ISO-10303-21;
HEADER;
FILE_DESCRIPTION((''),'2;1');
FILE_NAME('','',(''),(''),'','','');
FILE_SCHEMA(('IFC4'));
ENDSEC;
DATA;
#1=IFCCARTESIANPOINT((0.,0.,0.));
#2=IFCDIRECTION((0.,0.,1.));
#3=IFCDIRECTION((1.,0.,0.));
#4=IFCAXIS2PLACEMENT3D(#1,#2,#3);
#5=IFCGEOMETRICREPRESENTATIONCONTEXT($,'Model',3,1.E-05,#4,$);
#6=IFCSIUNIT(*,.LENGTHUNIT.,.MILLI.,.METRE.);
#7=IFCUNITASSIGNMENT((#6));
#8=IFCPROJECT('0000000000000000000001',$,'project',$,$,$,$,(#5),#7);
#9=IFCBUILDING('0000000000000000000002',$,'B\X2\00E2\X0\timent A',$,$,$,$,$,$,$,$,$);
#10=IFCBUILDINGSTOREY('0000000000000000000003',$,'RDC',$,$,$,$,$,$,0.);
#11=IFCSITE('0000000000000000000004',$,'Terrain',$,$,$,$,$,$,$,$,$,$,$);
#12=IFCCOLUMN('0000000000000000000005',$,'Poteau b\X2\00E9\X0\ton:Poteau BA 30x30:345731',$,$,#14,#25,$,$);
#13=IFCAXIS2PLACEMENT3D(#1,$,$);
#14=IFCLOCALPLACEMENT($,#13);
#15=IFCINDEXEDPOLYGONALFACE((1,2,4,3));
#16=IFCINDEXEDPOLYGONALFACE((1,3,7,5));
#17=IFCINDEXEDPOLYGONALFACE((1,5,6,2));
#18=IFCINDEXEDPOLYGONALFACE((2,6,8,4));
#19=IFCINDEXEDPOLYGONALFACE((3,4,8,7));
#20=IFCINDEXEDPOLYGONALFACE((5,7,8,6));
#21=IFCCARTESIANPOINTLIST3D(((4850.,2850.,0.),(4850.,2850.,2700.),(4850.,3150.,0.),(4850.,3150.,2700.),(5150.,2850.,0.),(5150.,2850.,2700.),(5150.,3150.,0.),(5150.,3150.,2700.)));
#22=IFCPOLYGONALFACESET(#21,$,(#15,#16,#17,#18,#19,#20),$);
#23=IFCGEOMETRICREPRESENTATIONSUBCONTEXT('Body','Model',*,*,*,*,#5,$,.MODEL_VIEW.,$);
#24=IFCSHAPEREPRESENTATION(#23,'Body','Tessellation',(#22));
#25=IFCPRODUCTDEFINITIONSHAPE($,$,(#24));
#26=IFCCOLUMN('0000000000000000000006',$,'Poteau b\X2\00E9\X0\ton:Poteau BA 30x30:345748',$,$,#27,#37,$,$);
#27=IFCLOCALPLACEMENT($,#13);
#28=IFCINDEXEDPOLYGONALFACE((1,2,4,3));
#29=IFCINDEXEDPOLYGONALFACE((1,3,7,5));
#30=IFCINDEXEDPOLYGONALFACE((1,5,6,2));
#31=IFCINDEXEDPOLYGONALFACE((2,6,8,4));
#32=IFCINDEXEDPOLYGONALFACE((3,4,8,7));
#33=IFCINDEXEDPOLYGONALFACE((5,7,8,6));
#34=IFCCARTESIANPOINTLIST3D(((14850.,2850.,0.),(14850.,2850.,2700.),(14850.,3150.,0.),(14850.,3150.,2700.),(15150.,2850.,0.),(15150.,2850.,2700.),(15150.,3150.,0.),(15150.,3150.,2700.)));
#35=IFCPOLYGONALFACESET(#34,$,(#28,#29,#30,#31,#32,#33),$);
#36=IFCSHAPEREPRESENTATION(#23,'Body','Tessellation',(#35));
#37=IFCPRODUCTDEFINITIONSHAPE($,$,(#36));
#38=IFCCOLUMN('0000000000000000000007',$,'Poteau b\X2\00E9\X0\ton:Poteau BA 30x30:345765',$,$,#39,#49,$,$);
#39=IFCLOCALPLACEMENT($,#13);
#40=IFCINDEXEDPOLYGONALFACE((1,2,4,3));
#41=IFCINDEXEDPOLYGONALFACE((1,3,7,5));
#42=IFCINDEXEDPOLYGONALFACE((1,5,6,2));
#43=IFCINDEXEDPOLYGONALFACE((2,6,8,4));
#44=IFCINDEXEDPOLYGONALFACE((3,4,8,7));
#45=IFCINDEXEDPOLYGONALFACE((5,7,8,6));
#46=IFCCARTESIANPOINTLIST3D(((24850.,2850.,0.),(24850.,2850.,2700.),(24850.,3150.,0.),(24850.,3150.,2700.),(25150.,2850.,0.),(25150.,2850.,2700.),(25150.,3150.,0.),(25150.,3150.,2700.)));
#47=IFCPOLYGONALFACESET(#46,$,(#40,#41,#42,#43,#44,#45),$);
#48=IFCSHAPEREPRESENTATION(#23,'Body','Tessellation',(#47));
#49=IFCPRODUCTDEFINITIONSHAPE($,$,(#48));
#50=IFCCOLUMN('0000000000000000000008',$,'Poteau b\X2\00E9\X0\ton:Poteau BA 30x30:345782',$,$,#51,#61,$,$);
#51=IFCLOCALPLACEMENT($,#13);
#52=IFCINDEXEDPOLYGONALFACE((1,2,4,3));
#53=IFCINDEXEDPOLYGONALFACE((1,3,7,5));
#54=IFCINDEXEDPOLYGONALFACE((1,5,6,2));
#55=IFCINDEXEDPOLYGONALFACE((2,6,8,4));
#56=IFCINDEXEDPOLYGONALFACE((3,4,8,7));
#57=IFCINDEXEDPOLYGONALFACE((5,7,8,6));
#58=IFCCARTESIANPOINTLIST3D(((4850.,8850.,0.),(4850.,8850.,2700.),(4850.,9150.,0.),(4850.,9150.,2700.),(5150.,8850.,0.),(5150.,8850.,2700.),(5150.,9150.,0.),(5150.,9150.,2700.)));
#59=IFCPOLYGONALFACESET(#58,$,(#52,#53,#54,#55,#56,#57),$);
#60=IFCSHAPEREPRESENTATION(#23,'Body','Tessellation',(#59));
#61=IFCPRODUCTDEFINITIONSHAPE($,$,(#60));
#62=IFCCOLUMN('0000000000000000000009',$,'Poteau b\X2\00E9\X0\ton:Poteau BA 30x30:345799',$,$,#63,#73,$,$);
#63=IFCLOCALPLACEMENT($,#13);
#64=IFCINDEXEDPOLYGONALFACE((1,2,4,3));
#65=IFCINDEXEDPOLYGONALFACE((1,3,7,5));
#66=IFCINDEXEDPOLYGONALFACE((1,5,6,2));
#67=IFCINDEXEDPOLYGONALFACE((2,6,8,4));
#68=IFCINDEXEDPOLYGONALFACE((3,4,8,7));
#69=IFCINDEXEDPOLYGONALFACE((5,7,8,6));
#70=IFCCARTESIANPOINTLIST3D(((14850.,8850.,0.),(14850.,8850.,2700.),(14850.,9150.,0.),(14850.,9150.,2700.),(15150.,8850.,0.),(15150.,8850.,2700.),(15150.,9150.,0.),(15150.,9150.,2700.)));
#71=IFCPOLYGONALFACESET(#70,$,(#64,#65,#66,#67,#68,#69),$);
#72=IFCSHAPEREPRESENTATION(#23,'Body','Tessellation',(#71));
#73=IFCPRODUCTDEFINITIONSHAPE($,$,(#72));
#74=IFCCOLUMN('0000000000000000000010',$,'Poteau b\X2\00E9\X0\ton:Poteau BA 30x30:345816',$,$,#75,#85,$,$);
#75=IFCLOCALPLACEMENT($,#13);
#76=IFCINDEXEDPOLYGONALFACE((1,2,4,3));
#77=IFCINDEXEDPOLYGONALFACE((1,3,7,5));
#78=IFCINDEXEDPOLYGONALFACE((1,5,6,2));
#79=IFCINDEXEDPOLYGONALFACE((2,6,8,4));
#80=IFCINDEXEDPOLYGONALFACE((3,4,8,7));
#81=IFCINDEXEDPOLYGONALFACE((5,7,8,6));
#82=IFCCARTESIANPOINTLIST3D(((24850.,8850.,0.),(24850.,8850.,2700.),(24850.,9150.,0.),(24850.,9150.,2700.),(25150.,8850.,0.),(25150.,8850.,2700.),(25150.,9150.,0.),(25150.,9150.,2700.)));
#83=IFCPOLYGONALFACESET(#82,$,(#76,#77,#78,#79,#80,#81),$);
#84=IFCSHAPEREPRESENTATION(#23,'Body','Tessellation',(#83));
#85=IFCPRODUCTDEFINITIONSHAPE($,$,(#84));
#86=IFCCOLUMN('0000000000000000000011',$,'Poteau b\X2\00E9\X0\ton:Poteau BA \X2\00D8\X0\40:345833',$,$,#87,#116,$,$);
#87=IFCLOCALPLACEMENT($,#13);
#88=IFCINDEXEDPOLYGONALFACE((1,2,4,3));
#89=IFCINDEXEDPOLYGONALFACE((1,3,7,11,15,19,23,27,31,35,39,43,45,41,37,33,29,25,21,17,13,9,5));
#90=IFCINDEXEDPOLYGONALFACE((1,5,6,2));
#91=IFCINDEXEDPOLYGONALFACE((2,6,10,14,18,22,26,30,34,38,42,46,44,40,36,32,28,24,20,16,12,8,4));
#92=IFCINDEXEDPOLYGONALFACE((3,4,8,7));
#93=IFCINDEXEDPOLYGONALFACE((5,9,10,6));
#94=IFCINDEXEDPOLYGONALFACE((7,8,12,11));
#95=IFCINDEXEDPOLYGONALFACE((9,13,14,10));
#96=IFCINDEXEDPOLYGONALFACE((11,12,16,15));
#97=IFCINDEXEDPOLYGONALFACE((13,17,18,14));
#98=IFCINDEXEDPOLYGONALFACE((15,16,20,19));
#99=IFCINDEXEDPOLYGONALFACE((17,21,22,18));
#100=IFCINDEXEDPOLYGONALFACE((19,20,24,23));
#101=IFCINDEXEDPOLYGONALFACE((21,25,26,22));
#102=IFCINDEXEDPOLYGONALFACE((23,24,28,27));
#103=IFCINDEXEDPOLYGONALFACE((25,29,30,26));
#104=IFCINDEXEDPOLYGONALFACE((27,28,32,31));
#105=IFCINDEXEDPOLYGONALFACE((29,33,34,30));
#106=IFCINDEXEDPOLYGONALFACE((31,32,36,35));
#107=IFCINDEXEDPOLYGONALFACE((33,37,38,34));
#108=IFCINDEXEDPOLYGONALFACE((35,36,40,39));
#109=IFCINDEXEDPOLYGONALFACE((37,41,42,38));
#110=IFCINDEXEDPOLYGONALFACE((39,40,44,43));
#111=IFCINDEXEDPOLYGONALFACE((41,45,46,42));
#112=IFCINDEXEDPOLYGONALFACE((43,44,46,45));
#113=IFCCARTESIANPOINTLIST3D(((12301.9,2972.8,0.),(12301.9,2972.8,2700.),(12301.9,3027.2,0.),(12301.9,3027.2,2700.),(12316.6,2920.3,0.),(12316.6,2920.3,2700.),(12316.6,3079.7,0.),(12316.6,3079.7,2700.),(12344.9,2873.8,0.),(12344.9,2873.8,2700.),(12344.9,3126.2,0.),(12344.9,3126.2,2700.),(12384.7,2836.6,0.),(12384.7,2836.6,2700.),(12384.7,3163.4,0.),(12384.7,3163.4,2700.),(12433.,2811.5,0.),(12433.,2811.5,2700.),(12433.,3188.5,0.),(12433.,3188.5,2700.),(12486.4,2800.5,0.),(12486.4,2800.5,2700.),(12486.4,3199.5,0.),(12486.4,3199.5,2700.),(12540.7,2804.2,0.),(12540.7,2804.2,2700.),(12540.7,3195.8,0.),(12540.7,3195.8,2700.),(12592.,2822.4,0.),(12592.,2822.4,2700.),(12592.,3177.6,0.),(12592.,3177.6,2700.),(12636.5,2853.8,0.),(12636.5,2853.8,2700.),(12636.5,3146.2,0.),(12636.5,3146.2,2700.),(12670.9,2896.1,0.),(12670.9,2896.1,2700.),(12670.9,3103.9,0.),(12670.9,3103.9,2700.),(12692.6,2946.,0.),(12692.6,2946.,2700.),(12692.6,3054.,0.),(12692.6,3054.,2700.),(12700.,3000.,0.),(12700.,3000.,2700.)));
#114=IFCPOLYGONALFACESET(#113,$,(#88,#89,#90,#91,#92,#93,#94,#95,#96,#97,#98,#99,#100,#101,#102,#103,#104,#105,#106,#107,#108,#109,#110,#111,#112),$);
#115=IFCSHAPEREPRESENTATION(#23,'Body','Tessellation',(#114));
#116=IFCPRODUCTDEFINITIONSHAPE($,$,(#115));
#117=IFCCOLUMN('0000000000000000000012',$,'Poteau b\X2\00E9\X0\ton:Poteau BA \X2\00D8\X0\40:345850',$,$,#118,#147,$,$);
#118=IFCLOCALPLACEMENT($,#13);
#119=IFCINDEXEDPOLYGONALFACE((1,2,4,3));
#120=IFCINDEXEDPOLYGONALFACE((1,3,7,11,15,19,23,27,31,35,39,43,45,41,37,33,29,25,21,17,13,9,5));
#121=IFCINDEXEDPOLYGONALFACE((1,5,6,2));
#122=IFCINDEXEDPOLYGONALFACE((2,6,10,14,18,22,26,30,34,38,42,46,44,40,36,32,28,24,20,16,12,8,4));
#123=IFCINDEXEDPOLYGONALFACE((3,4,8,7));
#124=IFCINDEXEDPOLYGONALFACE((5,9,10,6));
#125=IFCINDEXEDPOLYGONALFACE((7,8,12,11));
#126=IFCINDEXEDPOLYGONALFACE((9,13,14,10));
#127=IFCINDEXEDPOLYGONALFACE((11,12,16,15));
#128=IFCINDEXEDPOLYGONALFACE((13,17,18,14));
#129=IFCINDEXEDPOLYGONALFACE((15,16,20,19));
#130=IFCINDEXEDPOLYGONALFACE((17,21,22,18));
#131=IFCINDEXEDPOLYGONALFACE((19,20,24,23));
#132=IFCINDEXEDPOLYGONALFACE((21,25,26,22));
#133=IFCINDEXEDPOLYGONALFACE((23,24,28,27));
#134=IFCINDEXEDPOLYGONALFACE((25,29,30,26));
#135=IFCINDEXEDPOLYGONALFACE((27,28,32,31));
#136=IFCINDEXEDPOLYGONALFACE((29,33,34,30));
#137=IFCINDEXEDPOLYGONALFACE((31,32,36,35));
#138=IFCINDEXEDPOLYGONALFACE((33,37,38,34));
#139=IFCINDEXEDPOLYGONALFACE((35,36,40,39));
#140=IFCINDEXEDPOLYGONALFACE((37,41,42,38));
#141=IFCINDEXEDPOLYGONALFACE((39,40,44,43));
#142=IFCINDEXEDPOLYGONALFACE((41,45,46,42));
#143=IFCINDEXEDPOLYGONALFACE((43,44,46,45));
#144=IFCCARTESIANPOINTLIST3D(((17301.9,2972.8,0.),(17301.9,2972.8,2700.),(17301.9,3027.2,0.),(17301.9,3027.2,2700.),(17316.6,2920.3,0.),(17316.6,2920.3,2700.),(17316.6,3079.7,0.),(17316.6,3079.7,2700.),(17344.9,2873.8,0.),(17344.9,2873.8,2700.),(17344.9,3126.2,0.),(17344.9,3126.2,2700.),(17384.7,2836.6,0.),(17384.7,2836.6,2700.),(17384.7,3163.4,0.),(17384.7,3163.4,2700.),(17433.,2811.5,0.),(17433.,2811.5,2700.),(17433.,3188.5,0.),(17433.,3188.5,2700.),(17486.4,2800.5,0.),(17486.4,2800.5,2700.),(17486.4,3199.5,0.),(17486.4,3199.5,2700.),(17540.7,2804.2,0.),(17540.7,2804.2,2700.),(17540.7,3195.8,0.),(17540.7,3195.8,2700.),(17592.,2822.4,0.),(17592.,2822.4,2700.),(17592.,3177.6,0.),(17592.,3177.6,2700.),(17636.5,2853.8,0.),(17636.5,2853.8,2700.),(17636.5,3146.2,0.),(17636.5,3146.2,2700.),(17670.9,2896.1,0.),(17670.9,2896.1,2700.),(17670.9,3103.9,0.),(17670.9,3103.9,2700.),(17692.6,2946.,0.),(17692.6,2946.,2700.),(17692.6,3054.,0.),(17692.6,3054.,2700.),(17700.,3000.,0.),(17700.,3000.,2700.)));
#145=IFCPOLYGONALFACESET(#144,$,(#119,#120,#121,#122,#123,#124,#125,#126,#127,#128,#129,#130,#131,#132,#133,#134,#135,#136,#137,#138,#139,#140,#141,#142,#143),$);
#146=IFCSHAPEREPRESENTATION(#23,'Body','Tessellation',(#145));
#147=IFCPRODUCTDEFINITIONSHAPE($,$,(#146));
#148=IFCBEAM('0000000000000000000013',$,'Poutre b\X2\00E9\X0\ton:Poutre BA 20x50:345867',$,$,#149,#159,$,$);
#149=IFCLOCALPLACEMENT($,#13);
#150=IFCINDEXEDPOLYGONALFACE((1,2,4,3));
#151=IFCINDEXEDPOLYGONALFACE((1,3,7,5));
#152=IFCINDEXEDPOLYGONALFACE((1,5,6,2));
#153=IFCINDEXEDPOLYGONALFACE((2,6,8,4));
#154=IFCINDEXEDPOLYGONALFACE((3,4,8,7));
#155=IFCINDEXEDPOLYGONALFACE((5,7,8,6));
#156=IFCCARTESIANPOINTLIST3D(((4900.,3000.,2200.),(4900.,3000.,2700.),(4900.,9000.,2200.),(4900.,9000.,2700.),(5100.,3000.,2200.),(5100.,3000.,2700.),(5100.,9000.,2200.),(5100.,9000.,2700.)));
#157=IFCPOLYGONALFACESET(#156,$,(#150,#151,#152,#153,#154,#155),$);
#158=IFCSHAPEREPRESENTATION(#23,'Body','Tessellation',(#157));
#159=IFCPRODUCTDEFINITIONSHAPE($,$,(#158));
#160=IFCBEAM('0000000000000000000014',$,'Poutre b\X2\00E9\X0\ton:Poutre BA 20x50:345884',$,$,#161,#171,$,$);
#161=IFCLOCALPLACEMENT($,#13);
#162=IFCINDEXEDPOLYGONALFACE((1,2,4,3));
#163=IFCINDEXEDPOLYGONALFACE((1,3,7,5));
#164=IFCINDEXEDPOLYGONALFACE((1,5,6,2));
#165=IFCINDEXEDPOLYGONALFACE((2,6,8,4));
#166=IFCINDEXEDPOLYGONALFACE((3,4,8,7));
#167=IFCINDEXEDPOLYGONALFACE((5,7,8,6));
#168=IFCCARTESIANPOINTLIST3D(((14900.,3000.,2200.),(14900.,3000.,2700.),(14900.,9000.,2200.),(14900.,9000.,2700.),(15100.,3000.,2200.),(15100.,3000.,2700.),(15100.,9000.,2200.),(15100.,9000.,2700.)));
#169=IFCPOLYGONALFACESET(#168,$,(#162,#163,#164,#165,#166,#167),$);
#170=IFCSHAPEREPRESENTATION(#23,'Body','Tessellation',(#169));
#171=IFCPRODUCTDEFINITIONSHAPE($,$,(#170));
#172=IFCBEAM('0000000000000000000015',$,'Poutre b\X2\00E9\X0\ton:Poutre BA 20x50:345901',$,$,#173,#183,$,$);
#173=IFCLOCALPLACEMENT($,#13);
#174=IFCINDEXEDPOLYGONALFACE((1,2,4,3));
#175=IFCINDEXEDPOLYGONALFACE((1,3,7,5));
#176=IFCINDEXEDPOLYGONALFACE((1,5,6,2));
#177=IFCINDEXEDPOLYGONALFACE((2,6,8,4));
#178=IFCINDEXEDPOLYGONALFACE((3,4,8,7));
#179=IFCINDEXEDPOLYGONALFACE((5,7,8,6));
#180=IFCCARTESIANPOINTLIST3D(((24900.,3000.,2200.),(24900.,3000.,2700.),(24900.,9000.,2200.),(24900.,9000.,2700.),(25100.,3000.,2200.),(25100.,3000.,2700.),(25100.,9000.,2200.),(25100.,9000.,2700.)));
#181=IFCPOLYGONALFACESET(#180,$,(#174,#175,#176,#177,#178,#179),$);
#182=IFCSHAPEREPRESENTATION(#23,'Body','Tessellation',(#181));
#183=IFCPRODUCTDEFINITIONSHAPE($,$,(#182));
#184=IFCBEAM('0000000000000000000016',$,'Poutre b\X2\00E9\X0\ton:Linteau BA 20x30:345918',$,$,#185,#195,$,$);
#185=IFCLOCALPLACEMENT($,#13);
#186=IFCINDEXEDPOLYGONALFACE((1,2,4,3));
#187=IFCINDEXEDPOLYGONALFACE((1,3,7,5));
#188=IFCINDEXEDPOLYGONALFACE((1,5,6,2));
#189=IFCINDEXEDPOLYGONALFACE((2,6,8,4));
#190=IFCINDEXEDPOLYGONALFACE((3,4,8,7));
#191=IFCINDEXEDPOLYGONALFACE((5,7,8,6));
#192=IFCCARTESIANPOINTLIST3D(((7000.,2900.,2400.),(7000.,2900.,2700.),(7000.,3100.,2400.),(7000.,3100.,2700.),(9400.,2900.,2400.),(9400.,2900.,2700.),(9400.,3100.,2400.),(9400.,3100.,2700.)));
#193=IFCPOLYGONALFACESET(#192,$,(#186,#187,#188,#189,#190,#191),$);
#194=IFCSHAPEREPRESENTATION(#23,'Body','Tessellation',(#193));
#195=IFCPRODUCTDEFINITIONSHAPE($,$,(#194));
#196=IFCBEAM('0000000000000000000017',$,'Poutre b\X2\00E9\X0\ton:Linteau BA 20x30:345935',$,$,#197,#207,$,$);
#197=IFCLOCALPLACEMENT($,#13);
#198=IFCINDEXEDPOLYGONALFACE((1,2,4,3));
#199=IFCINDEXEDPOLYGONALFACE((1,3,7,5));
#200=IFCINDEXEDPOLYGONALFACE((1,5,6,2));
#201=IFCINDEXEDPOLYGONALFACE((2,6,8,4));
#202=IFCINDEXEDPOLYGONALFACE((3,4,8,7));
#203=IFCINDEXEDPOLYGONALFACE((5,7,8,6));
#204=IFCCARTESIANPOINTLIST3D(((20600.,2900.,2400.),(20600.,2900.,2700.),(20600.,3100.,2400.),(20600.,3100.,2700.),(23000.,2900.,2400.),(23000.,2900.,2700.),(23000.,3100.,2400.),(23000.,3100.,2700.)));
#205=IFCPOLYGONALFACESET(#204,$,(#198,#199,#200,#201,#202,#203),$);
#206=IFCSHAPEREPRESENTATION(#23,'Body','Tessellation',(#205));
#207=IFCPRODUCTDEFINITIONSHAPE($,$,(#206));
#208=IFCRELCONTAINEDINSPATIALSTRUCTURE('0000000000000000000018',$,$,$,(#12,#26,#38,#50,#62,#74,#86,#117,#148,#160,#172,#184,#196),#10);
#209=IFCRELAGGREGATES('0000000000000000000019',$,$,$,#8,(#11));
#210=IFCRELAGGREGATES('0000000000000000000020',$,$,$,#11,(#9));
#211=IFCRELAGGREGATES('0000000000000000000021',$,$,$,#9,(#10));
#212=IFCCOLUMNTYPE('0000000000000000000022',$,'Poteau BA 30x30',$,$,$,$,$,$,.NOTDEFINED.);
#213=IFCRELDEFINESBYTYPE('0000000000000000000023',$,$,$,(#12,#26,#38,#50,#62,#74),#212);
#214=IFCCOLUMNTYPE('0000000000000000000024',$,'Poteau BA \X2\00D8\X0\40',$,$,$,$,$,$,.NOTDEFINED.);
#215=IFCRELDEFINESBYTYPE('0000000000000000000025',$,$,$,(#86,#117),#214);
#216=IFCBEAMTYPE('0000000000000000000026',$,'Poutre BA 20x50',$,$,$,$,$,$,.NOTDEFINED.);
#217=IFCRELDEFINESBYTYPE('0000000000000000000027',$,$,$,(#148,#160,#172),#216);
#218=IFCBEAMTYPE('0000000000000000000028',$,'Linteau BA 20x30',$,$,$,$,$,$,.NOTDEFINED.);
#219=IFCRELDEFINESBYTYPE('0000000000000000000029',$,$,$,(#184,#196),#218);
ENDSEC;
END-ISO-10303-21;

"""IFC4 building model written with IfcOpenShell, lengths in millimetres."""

from ifc_helpers import new_model, si_unit, frame, frame_2d, origin_with_axes, origin_2d, place, context, subcontext, project, spatial, rectangle, circle, extrude, type_object, element, save


model = new_model("IFC4")

# Units and contexts
model_context = context("Model", 3, precision=1e-05, world=origin_with_axes())
body_context = subcontext(model_context, "Body", "Model", "MODEL_VIEW")
ifc_project = project(units=[si_unit("LENGTHUNIT", "METRE", prefix="MILLI")], contexts=[model_context])

# Site, building, storey
site = spatial("IfcSite", under=ifc_project, Name="Terrain")
building = spatial("IfcBuilding", under=site, Name="Bâtiment A")
storey = spatial("IfcBuildingStorey", under=building, Name="RDC", Elevation=0.0)

# Columns
column_type_1 = type_object("IfcColumnType", Name="Poteau BA 30x30", PredefinedType="NOTDEFINED")
column_1_placement = place(None, origin_with_axes())
element("IfcColumn", 1, at=column_1_placement, inside=storey, type_object=column_type_1, Name="Poteau béton:Poteau BA 30x30:345731", context=body_context, shape_type="SweptSolid", body=[
    extrude(rectangle(XDim=300.0, YDim=300.0, at=frame_2d((5000.0, 3000.0))), origin_with_axes(), (0.0, 0.0, 1.0), 2700.0),
])
column_2_placement = place(None, origin_with_axes())
element("IfcColumn", 2, at=column_2_placement, inside=storey, type_object=column_type_1, Name="Poteau béton:Poteau BA 30x30:345748", context=body_context, shape_type="SweptSolid", body=[
    extrude(rectangle(XDim=300.0, YDim=300.0, at=frame_2d((15000.0, 3000.0))), origin_with_axes(), (0.0, 0.0, 1.0), 2700.0),
])
column_3_placement = place(None, origin_with_axes())
element("IfcColumn", 3, at=column_3_placement, inside=storey, type_object=column_type_1, Name="Poteau béton:Poteau BA 30x30:345765", context=body_context, shape_type="SweptSolid", body=[
    extrude(rectangle(XDim=300.0, YDim=300.0, at=frame_2d((25000.0, 3000.0))), origin_with_axes(), (0.0, 0.0, 1.0), 2700.0),
])
column_4_placement = place(None, origin_with_axes())
element("IfcColumn", 4, at=column_4_placement, inside=storey, type_object=column_type_1, Name="Poteau béton:Poteau BA 30x30:345782", context=body_context, shape_type="SweptSolid", body=[
    extrude(rectangle(XDim=300.0, YDim=300.0, at=frame_2d((5000.0, 9000.0))), origin_with_axes(), (0.0, 0.0, 1.0), 2700.0),
])
column_5_placement = place(None, origin_with_axes())
element("IfcColumn", 5, at=column_5_placement, inside=storey, type_object=column_type_1, Name="Poteau béton:Poteau BA 30x30:345799", context=body_context, shape_type="SweptSolid", body=[
    extrude(rectangle(XDim=300.0, YDim=300.0, at=frame_2d((15000.0, 9000.0))), origin_with_axes(), (0.0, 0.0, 1.0), 2700.0),
])
column_6_placement = place(None, origin_with_axes())
element("IfcColumn", 6, at=column_6_placement, inside=storey, type_object=column_type_1, Name="Poteau béton:Poteau BA 30x30:345816", context=body_context, shape_type="SweptSolid", body=[
    extrude(rectangle(XDim=300.0, YDim=300.0, at=frame_2d((25000.0, 9000.0))), origin_with_axes(), (0.0, 0.0, 1.0), 2700.0),
])
column_type_2 = type_object("IfcColumnType", Name="Poteau BA Ø40", PredefinedType="NOTDEFINED")
column_7_placement = place(None, origin_with_axes())
element("IfcColumn", 7, at=column_7_placement, inside=storey, type_object=column_type_2, Name="Poteau béton:Poteau BA Ø40:345833", context=body_context, shape_type="SweptSolid", body=[
    extrude(circle(Radius=200.0, at=origin_2d()), frame((12500.0, 3000.0, 0.0), z_axis=(0.0, 0.0, 1.0), x_axis=(1.0, 0.0, 0.0)), (0.0, 0.0, 1.0), 2700.0),
])
column_8_placement = place(None, origin_with_axes())
element("IfcColumn", 8, at=column_8_placement, inside=storey, type_object=column_type_2, Name="Poteau béton:Poteau BA Ø40:345850", context=body_context, shape_type="SweptSolid", body=[
    extrude(circle(Radius=200.0, at=origin_2d()), frame((17500.0, 3000.0, 0.0), z_axis=(0.0, 0.0, 1.0), x_axis=(1.0, 0.0, 0.0)), (0.0, 0.0, 1.0), 2700.0),
])

# Beams
beam_type_1 = type_object("IfcBeamType", Name="Poutre BA 20x50", PredefinedType="NOTDEFINED")
beam_1_placement = place(None, origin_with_axes())
element("IfcBeam", 9, at=beam_1_placement, inside=storey, type_object=beam_type_1, Name="Poutre béton:Poutre BA 20x50:345867", context=body_context, shape_type="SweptSolid", body=[
    extrude(rectangle(XDim=200.0, YDim=6000.0, at=frame_2d((5000.0, 6000.0))), frame((0.0, 0.0, 2200.0), z_axis=(0.0, 0.0, 1.0), x_axis=(1.0, 0.0, 0.0)), (0.0, 0.0, 1.0), 500.0),
])
beam_2_placement = place(None, origin_with_axes())
element("IfcBeam", 10, at=beam_2_placement, inside=storey, type_object=beam_type_1, Name="Poutre béton:Poutre BA 20x50:345884", context=body_context, shape_type="SweptSolid", body=[
    extrude(rectangle(XDim=200.0, YDim=6000.0, at=frame_2d((15000.0, 6000.0))), frame((0.0, 0.0, 2200.0), z_axis=(0.0, 0.0, 1.0), x_axis=(1.0, 0.0, 0.0)), (0.0, 0.0, 1.0), 500.0),
])
beam_3_placement = place(None, origin_with_axes())
element("IfcBeam", 11, at=beam_3_placement, inside=storey, type_object=beam_type_1, Name="Poutre béton:Poutre BA 20x50:345901", context=body_context, shape_type="SweptSolid", body=[
    extrude(rectangle(XDim=200.0, YDim=6000.0, at=frame_2d((25000.0, 6000.0))), frame((0.0, 0.0, 2200.0), z_axis=(0.0, 0.0, 1.0), x_axis=(1.0, 0.0, 0.0)), (0.0, 0.0, 1.0), 500.0),
])
beam_type_2 = type_object("IfcBeamType", Name="Linteau BA 20x30", PredefinedType="NOTDEFINED")
beam_4_placement = place(None, origin_with_axes())
element("IfcBeam", 12, at=beam_4_placement, inside=storey, type_object=beam_type_2, Name="Poutre béton:Linteau BA 20x30:345918", context=body_context, shape_type="SweptSolid", body=[
    extrude(rectangle(XDim=2400.0, YDim=200.0, at=frame_2d((8200.0, 3000.0))), frame((0.0, 0.0, 2400.0), z_axis=(0.0, 0.0, 1.0), x_axis=(1.0, 0.0, 0.0)), (0.0, 0.0, 1.0), 300.0),
])
beam_5_placement = place(None, origin_with_axes())
element("IfcBeam", 13, at=beam_5_placement, inside=storey, type_object=beam_type_2, Name="Poutre béton:Linteau BA 20x30:345935", context=body_context, shape_type="SweptSolid", body=[
    extrude(rectangle(XDim=2400.0, YDim=200.0, at=frame_2d((21800.0, 3000.0))), frame((0.0, 0.0, 2400.0), z_axis=(0.0, 0.0, 1.0), x_axis=(1.0, 0.0, 0.0)), (0.0, 0.0, 1.0), 300.0),
])

save(model, "model.ifc")
